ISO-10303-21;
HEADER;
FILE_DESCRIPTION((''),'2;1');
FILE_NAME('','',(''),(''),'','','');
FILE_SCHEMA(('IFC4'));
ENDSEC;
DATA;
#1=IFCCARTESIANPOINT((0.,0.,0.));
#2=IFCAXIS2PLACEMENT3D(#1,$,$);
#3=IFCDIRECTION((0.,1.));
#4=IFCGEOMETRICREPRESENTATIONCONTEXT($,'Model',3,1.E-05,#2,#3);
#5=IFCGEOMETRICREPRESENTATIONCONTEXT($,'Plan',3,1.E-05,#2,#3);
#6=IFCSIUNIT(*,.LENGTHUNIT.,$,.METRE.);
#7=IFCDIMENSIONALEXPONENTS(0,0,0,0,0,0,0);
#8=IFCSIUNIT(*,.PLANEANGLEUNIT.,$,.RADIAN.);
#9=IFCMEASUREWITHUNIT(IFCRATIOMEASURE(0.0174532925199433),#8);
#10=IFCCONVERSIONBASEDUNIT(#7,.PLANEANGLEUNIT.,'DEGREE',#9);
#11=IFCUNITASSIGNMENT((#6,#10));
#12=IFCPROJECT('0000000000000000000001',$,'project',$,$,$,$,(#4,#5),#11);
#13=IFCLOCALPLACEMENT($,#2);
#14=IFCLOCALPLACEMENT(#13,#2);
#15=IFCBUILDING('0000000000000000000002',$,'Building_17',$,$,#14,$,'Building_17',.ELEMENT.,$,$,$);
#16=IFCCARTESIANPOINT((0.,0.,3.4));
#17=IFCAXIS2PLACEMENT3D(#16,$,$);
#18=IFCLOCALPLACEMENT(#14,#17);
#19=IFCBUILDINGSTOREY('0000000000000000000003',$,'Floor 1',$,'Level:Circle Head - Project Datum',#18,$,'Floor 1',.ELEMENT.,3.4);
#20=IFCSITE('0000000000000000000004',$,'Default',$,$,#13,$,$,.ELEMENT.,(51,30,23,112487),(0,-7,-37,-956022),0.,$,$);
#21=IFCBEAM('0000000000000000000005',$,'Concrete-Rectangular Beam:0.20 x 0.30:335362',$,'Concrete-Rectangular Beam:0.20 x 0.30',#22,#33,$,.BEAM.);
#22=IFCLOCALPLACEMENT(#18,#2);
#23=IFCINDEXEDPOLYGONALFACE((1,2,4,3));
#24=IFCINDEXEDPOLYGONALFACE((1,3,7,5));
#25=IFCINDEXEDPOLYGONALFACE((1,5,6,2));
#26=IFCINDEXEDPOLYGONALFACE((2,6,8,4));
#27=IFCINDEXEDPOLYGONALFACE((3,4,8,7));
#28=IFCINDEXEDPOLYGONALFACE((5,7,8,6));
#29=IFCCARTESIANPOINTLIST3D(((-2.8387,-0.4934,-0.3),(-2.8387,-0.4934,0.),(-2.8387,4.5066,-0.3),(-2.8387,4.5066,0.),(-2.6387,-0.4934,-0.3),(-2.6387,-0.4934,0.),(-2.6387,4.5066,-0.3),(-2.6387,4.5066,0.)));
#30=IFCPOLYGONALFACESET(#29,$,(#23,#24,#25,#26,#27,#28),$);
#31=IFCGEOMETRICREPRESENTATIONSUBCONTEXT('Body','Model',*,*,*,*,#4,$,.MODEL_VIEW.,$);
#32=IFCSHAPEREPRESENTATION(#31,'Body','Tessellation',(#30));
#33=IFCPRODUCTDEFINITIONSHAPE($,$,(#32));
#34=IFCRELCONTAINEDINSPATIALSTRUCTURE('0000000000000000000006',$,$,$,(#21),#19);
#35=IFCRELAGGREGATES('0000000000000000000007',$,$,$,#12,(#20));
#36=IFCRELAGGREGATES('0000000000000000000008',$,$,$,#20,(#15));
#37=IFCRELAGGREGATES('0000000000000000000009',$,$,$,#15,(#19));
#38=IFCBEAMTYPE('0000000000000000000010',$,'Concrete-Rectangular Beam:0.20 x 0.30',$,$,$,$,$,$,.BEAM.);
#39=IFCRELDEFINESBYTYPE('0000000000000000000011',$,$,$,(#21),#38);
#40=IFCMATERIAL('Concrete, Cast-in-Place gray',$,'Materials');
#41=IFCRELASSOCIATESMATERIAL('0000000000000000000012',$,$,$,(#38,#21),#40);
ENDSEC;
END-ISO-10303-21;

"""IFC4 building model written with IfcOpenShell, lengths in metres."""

from ifc_helpers import new_model, entity, si_unit, converted_unit, direction, frame, origin, place, context, subcontext, project, spatial, indexed_curve, outline, extrude, source, transform, mapped, material, type_object, type_shapes, element, save


model = new_model("IFC4")

# Units and contexts
model_context = context("Model", 3, precision=1e-05, world=origin(), true_north=direction((0.0, 1.0)))
plan_context = context("Plan", 3, precision=1e-05, world=origin(), true_north=direction((0.0, 1.0)))
body_context = subcontext(model_context, "Body", "Model", "MODEL_VIEW")
ifc_project = project(units=[si_unit("LENGTHUNIT", "METRE"), converted_unit("PLANEANGLEUNIT", "DEGREE", entity("IfcRatioMeasure", 0.0174532925199433), si_unit("PLANEANGLEUNIT", "RADIAN"), dimensions=[0, 0, 0, 0, 0, 0, 0])], contexts=[model_context, plan_context])

# Site, building, storey
site_placement = place(None, origin())
site = spatial("IfcSite", under=ifc_project, at=site_placement, Name="Default", CompositionType="ELEMENT", RefLatitude=(51, 30, 23, 112487), RefLongitude=(0, -7, -37, -956022), RefElevation=0.0)
building_placement = place(site_placement, origin())
building = spatial("IfcBuilding", under=site, at=building_placement, Name="Building_17", LongName="Building_17", CompositionType="ELEMENT")
storey_placement = place(building_placement, frame((0.0, 0.0, 3.4)))
storey = spatial("IfcBuildingStorey", under=building, at=storey_placement, Name="Floor 1", ObjectType="Level:Circle Head - Project Datum", LongName="Floor 1", CompositionType="ELEMENT", Elevation=3.4)

# Beam
ifc_material_1 = material(Name="Concrete, Cast-in-Place gray", Category="Materials")
beam_type_1 = type_object("IfcBeamType", Name="Concrete-Rectangular Beam:0.20 x 0.30", PredefinedType="BEAM", material=ifc_material_1)
shared_shape_1 = source(origin(), body_context, "Body", "SweptSolid", [
    extrude(outline(indexed_curve([(-0.1, -0.15), (0.1, -0.15), (0.1, 0.15), (-0.1, 0.15), (-0.1, -0.15)], self_intersect=False)), frame((-2.7387, -0.4934, 3.25), z_axis=(0.0, 1.0, 0.0), x_axis=(-1.0, 0.0, 0.0)), (0.0, 0.0, 1.0), 5.0),
])
type_shapes(beam_type_1, [shared_shape_1])
beam_1_placement = place(storey_placement, frame((0.0, 0.0, -3.4)))
element("IfcBeam", 1, at=beam_1_placement, inside=storey, type_object=beam_type_1, material=ifc_material_1, Name="Concrete-Rectangular Beam:0.20 x 0.30:335362", ObjectType="Concrete-Rectangular Beam:0.20 x 0.30", PredefinedType="BEAM", context=body_context, shape_type="MappedRepresentation", body=[
    mapped(shared_shape_1, transform((0.0, 0.0, 0.0), scale=1.0)),
])

save(model, "model.ifc")
